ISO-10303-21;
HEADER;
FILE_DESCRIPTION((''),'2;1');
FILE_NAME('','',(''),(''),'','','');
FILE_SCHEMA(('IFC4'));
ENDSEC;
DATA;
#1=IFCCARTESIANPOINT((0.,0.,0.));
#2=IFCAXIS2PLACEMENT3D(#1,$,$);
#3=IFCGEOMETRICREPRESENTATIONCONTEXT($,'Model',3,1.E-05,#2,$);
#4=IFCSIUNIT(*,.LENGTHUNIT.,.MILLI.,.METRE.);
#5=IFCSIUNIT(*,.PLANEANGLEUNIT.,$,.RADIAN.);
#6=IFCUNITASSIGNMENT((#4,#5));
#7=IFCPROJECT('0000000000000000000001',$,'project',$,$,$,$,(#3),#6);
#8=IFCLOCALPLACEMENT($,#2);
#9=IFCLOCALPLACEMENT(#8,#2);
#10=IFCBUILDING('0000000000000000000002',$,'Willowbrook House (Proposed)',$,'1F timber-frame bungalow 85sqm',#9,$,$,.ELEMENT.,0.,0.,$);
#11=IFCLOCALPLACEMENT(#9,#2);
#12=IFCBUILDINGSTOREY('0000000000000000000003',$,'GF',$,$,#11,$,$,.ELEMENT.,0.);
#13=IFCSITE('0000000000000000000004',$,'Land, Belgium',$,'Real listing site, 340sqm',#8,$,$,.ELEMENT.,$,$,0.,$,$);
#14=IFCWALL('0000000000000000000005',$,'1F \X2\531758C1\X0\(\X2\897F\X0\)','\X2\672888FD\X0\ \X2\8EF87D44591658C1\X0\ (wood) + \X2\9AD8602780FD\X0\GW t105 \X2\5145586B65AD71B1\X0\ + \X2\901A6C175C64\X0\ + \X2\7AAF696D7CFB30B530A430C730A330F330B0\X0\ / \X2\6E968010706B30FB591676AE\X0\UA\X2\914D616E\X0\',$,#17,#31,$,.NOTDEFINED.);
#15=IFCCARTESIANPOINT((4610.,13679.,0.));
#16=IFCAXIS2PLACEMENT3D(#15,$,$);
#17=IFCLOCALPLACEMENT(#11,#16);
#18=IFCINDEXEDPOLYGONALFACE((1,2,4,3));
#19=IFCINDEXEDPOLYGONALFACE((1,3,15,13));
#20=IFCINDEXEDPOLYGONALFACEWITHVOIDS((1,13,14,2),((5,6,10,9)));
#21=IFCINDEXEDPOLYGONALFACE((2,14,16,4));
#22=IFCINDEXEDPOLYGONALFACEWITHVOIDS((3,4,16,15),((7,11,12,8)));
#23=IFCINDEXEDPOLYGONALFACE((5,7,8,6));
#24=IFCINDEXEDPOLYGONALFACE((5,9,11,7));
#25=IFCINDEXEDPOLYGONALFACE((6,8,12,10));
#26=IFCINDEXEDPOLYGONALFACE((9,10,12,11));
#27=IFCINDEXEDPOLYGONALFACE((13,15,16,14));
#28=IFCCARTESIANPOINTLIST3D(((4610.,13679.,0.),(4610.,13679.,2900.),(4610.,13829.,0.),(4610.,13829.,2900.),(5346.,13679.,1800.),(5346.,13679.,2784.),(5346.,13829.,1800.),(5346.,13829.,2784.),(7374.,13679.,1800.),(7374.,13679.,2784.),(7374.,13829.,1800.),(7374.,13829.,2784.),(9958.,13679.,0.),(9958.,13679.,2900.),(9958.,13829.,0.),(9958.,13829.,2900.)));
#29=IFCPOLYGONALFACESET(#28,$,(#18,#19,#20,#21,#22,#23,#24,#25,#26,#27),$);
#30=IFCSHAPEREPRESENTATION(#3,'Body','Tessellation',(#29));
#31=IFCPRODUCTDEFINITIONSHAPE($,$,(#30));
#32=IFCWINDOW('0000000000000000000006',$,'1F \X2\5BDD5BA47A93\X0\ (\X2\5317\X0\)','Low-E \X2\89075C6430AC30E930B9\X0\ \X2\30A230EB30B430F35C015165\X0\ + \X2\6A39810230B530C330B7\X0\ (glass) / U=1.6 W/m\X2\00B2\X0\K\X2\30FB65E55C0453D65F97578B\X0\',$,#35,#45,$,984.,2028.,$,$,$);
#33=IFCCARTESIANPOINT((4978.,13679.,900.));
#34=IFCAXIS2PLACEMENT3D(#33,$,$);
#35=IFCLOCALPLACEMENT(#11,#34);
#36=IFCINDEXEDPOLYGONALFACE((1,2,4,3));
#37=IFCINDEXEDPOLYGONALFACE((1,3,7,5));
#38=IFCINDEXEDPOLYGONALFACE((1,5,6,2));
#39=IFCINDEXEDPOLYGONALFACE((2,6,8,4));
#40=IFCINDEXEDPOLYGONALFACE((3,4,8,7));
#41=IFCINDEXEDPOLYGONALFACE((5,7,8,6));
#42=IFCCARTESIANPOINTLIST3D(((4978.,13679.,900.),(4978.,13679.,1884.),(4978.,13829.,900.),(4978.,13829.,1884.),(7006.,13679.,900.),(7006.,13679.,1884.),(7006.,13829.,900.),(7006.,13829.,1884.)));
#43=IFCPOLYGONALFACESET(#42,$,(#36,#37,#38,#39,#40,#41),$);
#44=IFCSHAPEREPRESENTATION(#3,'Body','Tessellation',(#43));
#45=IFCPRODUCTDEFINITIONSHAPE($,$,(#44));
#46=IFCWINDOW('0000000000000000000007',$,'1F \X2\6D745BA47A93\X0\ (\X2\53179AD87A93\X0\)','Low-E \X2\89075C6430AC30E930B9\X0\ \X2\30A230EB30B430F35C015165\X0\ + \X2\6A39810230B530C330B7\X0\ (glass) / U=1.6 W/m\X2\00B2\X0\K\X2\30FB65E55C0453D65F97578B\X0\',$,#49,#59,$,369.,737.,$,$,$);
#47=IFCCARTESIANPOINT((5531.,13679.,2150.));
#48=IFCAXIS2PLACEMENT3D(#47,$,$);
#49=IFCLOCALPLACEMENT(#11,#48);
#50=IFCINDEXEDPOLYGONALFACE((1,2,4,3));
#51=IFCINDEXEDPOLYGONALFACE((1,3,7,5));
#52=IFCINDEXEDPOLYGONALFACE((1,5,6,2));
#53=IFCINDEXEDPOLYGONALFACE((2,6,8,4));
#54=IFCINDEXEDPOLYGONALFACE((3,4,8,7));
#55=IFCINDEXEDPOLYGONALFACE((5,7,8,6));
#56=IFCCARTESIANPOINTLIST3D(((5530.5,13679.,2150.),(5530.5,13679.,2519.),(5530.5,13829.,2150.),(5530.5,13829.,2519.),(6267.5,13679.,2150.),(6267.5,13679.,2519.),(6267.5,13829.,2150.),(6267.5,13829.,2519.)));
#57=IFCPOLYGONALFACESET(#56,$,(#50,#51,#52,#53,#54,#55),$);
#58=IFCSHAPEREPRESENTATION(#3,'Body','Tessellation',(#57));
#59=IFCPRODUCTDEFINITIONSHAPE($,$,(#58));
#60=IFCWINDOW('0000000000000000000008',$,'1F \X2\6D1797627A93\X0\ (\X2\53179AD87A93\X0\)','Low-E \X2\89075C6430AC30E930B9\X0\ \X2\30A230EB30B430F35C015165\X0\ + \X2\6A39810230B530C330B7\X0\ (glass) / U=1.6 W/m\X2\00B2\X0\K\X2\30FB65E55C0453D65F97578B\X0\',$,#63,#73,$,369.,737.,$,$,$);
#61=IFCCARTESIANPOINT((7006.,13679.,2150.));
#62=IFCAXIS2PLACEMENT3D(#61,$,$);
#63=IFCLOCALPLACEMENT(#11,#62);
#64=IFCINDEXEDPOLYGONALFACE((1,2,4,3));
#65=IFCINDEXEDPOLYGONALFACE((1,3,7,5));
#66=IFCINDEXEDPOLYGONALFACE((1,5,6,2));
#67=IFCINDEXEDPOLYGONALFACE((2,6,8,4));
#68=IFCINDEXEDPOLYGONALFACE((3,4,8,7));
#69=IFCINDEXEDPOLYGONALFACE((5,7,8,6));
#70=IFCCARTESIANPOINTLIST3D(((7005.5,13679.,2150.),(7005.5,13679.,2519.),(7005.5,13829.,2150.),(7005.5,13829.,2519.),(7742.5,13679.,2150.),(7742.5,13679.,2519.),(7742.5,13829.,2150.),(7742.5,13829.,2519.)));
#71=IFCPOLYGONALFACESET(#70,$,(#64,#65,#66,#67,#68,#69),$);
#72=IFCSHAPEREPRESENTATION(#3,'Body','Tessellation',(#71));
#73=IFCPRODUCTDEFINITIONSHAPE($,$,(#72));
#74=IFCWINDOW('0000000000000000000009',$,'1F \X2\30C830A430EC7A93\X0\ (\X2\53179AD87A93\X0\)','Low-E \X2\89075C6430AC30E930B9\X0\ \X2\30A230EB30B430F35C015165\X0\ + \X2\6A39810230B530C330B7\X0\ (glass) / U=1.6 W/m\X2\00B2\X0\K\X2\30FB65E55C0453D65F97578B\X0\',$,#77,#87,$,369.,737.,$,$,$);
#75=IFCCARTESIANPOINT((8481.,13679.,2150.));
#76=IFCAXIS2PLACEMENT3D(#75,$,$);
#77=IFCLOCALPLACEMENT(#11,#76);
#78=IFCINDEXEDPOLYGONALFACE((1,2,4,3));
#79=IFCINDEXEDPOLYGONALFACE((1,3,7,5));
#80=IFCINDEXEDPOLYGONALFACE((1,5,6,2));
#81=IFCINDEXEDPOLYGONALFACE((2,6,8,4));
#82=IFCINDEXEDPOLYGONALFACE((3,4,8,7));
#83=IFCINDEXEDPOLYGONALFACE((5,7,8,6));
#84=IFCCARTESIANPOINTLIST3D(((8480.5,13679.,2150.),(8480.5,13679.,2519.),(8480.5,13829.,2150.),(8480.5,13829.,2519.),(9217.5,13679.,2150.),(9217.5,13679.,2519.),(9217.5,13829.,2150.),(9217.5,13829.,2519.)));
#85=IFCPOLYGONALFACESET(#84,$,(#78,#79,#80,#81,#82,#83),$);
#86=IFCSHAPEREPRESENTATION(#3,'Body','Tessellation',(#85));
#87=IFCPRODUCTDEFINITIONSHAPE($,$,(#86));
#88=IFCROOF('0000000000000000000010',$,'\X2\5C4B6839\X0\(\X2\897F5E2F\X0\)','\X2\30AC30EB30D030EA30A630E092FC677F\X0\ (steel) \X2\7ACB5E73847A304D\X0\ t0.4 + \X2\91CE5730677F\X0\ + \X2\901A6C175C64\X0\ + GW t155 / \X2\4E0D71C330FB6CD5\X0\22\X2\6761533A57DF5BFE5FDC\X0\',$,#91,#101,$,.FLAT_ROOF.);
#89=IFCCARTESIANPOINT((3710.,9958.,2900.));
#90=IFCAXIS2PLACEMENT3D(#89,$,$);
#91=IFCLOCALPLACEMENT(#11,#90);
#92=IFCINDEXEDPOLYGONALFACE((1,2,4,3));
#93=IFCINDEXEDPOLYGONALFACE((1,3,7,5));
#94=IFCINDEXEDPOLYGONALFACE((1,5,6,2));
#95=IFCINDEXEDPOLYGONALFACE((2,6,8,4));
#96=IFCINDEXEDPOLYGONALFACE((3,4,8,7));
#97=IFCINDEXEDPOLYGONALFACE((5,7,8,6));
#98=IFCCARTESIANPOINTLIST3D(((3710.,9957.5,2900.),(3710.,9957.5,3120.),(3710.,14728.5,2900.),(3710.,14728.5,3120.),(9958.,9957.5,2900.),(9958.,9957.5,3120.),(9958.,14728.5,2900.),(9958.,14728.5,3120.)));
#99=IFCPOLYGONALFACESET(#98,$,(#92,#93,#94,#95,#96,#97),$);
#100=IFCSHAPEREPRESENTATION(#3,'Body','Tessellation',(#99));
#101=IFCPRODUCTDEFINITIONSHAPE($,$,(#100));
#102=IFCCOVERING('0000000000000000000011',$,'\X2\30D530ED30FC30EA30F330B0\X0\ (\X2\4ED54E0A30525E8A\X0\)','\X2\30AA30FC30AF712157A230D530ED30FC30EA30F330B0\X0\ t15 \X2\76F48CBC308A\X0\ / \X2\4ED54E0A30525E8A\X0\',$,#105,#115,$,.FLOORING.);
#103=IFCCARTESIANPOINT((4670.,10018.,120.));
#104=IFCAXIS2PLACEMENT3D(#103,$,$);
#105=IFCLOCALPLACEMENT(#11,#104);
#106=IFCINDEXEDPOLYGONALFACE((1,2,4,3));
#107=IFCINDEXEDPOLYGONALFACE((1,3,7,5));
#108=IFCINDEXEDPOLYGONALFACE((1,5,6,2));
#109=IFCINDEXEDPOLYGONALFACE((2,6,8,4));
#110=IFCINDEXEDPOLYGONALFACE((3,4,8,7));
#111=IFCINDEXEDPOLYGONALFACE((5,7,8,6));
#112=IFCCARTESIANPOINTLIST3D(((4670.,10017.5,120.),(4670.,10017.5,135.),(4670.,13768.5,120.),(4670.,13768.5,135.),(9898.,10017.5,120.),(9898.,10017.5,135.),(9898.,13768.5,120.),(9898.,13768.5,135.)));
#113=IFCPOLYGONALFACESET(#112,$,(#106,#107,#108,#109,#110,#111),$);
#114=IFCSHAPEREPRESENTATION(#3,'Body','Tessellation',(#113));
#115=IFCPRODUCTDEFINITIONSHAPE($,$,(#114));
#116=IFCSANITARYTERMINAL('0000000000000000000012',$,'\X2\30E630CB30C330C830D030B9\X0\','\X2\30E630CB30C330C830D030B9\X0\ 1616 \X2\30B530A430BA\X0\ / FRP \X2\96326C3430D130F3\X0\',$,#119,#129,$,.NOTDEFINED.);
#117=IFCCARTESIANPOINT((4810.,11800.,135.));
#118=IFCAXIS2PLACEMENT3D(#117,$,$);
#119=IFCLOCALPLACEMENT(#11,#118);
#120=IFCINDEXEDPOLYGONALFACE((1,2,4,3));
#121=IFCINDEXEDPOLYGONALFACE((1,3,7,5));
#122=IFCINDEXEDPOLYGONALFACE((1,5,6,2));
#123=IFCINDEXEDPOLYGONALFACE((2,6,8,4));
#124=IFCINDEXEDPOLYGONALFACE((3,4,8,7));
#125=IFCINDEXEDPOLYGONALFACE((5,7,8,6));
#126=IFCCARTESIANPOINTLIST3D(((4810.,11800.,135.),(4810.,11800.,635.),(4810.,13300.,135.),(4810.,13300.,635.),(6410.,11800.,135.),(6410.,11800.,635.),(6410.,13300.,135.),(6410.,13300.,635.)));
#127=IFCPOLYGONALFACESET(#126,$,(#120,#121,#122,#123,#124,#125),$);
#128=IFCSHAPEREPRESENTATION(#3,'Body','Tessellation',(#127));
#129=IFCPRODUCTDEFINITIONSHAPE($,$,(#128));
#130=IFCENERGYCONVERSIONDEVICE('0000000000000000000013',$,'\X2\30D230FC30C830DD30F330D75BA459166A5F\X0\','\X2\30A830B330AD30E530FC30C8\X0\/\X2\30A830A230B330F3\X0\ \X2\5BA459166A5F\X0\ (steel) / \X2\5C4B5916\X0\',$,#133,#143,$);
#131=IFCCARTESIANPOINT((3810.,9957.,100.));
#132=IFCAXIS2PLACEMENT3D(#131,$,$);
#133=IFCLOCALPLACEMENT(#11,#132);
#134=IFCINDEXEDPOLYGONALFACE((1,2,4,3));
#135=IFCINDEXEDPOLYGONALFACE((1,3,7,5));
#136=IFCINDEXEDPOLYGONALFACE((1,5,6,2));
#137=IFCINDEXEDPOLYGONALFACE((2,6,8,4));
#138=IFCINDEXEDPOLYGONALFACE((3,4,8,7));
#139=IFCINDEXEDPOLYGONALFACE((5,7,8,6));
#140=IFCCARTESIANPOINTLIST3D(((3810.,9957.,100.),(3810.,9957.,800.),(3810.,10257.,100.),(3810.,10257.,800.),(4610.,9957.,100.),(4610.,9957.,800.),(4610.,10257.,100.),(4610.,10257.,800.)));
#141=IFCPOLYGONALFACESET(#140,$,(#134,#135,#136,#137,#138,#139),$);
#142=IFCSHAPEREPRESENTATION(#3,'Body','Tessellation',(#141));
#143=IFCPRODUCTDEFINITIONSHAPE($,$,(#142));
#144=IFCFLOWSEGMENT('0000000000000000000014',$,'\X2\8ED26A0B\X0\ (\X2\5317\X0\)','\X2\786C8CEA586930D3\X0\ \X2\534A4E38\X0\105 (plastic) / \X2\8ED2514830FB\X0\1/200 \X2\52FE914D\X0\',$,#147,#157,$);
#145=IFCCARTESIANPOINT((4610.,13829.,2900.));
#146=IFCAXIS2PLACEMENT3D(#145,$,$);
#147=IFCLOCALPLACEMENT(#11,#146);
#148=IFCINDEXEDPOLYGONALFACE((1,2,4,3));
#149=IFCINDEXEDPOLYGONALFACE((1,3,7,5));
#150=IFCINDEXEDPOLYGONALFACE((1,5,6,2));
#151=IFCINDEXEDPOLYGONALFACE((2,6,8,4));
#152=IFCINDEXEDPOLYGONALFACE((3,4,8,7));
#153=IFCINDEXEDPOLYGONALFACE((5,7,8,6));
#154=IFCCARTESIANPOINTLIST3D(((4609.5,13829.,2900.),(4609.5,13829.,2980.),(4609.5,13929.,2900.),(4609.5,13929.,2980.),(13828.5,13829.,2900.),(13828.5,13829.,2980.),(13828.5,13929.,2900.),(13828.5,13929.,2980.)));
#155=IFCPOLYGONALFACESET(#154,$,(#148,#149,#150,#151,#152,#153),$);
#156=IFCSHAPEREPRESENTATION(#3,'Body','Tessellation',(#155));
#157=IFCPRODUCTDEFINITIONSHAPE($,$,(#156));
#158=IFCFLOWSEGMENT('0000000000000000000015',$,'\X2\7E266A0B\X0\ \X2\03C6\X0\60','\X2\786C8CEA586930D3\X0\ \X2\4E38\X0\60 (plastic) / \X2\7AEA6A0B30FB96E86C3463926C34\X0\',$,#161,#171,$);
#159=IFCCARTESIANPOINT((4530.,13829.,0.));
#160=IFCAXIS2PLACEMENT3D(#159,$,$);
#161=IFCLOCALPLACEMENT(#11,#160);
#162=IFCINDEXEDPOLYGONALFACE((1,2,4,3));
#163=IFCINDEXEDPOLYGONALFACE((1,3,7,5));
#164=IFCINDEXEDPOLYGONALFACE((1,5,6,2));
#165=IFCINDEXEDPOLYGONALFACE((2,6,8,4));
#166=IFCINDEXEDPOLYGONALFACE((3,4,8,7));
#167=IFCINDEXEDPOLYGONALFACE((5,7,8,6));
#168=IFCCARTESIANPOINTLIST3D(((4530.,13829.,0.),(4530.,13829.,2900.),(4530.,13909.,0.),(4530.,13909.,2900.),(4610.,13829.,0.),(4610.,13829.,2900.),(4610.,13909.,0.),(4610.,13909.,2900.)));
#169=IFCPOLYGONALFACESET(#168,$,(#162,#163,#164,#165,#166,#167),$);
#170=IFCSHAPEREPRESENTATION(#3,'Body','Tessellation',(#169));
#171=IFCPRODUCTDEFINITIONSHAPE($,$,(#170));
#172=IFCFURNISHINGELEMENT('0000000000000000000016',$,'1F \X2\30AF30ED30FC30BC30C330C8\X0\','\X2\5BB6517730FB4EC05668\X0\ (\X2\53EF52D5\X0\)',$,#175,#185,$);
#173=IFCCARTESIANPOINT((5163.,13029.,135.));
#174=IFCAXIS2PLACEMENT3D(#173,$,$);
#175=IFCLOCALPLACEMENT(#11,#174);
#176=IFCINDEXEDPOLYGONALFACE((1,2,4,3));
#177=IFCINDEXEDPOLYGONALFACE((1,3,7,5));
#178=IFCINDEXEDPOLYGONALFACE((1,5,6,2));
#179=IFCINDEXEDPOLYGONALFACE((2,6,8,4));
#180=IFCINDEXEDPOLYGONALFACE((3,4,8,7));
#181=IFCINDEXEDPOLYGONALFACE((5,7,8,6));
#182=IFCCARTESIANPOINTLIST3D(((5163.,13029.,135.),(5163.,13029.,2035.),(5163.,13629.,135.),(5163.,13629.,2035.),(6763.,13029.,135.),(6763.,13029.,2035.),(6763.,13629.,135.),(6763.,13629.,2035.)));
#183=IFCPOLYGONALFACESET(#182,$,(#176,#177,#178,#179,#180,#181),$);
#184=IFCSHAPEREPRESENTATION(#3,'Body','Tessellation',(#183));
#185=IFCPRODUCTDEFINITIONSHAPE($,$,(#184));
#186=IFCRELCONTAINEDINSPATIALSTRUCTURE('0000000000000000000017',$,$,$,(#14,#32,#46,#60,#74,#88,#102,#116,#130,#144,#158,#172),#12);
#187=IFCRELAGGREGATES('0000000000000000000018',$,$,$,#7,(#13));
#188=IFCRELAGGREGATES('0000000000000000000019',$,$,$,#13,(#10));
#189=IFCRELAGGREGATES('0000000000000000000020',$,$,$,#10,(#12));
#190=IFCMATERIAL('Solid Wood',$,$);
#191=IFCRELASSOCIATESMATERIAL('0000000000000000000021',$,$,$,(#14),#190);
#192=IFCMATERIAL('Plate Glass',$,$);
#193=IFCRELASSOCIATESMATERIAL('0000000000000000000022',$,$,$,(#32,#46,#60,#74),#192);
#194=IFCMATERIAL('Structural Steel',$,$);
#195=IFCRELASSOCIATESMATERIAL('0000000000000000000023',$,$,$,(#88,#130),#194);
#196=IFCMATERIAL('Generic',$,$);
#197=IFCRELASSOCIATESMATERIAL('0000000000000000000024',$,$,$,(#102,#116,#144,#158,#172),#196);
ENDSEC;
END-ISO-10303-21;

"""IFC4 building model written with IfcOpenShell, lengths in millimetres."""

from ifc_helpers import new_model, si_unit, frame, frame_2d, origin, place, context, project, spatial, rectangle, extrude, material, element, fill, save


model = new_model("IFC4")

# Units and contexts
model_context = context("Model", 3, precision=1e-05, world=origin())
ifc_project = project(units=[si_unit("LENGTHUNIT", "METRE", prefix="MILLI"), si_unit("PLANEANGLEUNIT", "RADIAN")], contexts=[model_context])

# Site, building, storey
site_placement = place(None, origin())
site = spatial("IfcSite", under=ifc_project, at=site_placement, Name="Land, Belgium", ObjectType="Real listing site, 340sqm", CompositionType="ELEMENT", RefElevation=0.0)
building_placement = place(site_placement, origin())
building = spatial("IfcBuilding", under=site, at=building_placement, Name="Willowbrook House (Proposed)", ObjectType="1F timber-frame bungalow 85sqm", CompositionType="ELEMENT", ElevationOfRefHeight=0.0, ElevationOfTerrain=0.0)
storey_placement = place(building_placement, origin())
storey = spatial("IfcBuildingStorey", under=building, at=storey_placement, Name="GF", CompositionType="ELEMENT", Elevation=0.0)

# Shared definitions
ifc_material_1 = material(Name="Solid Wood")

# Wall, openings, windows
wall_1_placement = place(storey_placement, frame((4610.0, 13679.0, 0.0)))
wall_1 = element("IfcWall", 1, at=wall_1_placement, inside=storey, material=ifc_material_1, Name="1F 北壁(西)", Description="木製 軸組外壁 (wood) + 高性能GW t105 充填断熱 + 通気層 + 窯業系サイディング / 準耐火・外皮UA配慮", PredefinedType="NOTDEFINED", context=model_context, shape_type="SweptSolid", body=[
    extrude(rectangle(XDim=5348.0, YDim=150.0, at=frame_2d((2674.0, 75.0))), frame((4610.0, 13679.0, 0.0)), (0.0, 0.0, 1.0), 2900.0),
])
opening_1_placement = place(storey_placement, frame((4978.0, 13679.0, 900.0)))
opening_1 = element("IfcOpeningElement", 2, at=opening_1_placement, cuts=wall_1, PredefinedType="NOTDEFINED", context=model_context, shape_type="SweptSolid", body=[
    extrude(rectangle(XDim=2028.0, YDim=150.0, at=frame_2d((1014.0, 75.0))), frame((4978.0, 13679.0, 900.0)), (0.0, 0.0, 1.0), 984.0),
])
opening_2_placement = place(storey_placement, frame((5531.0, 13679.0, 2150.0)))
opening_2 = element("IfcOpeningElement", 3, at=opening_2_placement, cuts=wall_1, PredefinedType="NOTDEFINED", context=model_context, shape_type="SweptSolid", body=[
    extrude(rectangle(XDim=737.0, YDim=150.0, at=frame_2d((368.0, 75.0))), frame((5531.0, 13679.0, 2150.0)), (0.0, 0.0, 1.0), 369.0),
])
opening_3_placement = place(storey_placement, frame((7006.0, 13679.0, 2150.0)))
opening_3 = element("IfcOpeningElement", 4, at=opening_3_placement, cuts=wall_1, PredefinedType="NOTDEFINED", context=model_context, shape_type="SweptSolid", body=[
    extrude(rectangle(XDim=737.0, YDim=150.0, at=frame_2d((368.0, 75.0))), frame((7006.0, 13679.0, 2150.0)), (0.0, 0.0, 1.0), 369.0),
])
opening_4_placement = place(storey_placement, frame((8481.0, 13679.0, 2150.0)))
opening_4 = element("IfcOpeningElement", 5, at=opening_4_placement, cuts=wall_1, PredefinedType="NOTDEFINED", context=model_context, shape_type="SweptSolid", body=[
    extrude(rectangle(XDim=737.0, YDim=150.0, at=frame_2d((368.0, 75.0))), frame((8481.0, 13679.0, 2150.0)), (0.0, 0.0, 1.0), 369.0),
])
ifc_material_2 = material(Name="Plate Glass")
window_1_placement = place(storey_placement, frame((4978.0, 13679.0, 900.0)))
window_1 = element("IfcWindow", 6, at=window_1_placement, inside=storey, material=ifc_material_2, Name="1F 寝室窓 (北)", Description="Low-E 複層ガラス アルゴン封入 + 樹脂サッシ (glass) / U=1.6 W/m²K・日射取得型", OverallHeight=984.0, OverallWidth=2028.0, context=model_context, shape_type="SweptSolid", body=[
    extrude(rectangle(XDim=2028.0, YDim=150.0, at=frame_2d((1014.0, 75.0))), frame((4978.0, 13679.0, 900.0)), (0.0, 0.0, 1.0), 984.0),
])
fill(opening_1, window_1)
window_2_placement = place(storey_placement, frame((5531.0, 13679.0, 2150.0)))
window_2 = element("IfcWindow", 7, at=window_2_placement, inside=storey, material=ifc_material_2, Name="1F 浴室窓 (北高窓)", Description="Low-E 複層ガラス アルゴン封入 + 樹脂サッシ (glass) / U=1.6 W/m²K・日射取得型", OverallHeight=369.0, OverallWidth=737.0, context=model_context, shape_type="SweptSolid", body=[
    extrude(rectangle(XDim=737.0, YDim=150.0, at=frame_2d((368.0, 75.0))), frame((5531.0, 13679.0, 2150.0)), (0.0, 0.0, 1.0), 369.0),
])
fill(opening_2, window_2)
window_3_placement = place(storey_placement, frame((7006.0, 13679.0, 2150.0)))
window_3 = element("IfcWindow", 8, at=window_3_placement, inside=storey, material=ifc_material_2, Name="1F 洗面窓 (北高窓)", Description="Low-E 複層ガラス アルゴン封入 + 樹脂サッシ (glass) / U=1.6 W/m²K・日射取得型", OverallHeight=369.0, OverallWidth=737.0, context=model_context, shape_type="SweptSolid", body=[
    extrude(rectangle(XDim=737.0, YDim=150.0, at=frame_2d((368.0, 75.0))), frame((7006.0, 13679.0, 2150.0)), (0.0, 0.0, 1.0), 369.0),
])
fill(opening_3, window_3)
window_4_placement = place(storey_placement, frame((8481.0, 13679.0, 2150.0)))
window_4 = element("IfcWindow", 9, at=window_4_placement, inside=storey, material=ifc_material_2, Name="1F トイレ窓 (北高窓)", Description="Low-E 複層ガラス アルゴン封入 + 樹脂サッシ (glass) / U=1.6 W/m²K・日射取得型", OverallHeight=369.0, OverallWidth=737.0, context=model_context, shape_type="SweptSolid", body=[
    extrude(rectangle(XDim=737.0, YDim=150.0, at=frame_2d((368.0, 75.0))), frame((8481.0, 13679.0, 2150.0)), (0.0, 0.0, 1.0), 369.0),
])
fill(opening_4, window_4)

# Roof
ifc_material_3 = material(Name="Structural Steel")
roof_placement = place(storey_placement, frame((3710.0, 9958.0, 2900.0)))
element("IfcRoof", 10, at=roof_placement, inside=storey, material=ifc_material_3, Name="屋根(西帯)", Description="ガルバリウム鋼板 (steel) 立平葺き t0.4 + 野地板 + 通気層 + GW t155 / 不燃・法22条区域対応", PredefinedType="FLAT_ROOF", context=model_context, shape_type="SweptSolid", body=[
    extrude(rectangle(XDim=6248.0, YDim=4771.0, at=frame_2d((3124.0, 2385.0))), frame((3710.0, 9958.0, 2900.0)), (0.0, 0.0, 1.0), 220.0),
])

# Covering
ifc_material_4 = material(Name="Generic")
covering_placement = place(storey_placement, frame((4670.0, 10018.0, 120.0)))
element("IfcCovering", 11, at=covering_placement, inside=storey, material=ifc_material_4, Name="フローリング (仕上げ床)", Description="オーク無垢フローリング t15 直貼り / 仕上げ床", PredefinedType="FLOORING", context=model_context, shape_type="SweptSolid", body=[
    extrude(rectangle(XDim=5228.0, YDim=3751.0, at=frame_2d((2614.0, 1875.0))), frame((4670.0, 10018.0, 120.0)), (0.0, 0.0, 1.0), 15.0),
])

# Sanitary terminal
sanitary_terminal_placement = place(storey_placement, frame((4810.0, 11800.0, 135.0)))
element("IfcSanitaryTerminal", 12, at=sanitary_terminal_placement, inside=storey, material=ifc_material_4, Name="ユニットバス", Description="ユニットバス 1616 サイズ / FRP 防水パン", PredefinedType="NOTDEFINED", context=model_context, shape_type="SweptSolid", body=[
    extrude(rectangle(XDim=1600.0, YDim=1500.0, at=frame_2d((800.0, 750.0))), frame((4810.0, 11800.0, 135.0)), (0.0, 0.0, 1.0), 500.0),
])

# Energy conversion device
energy_conversion_device_placement = place(storey_placement, frame((3810.0, 9957.0, 100.0)))
element("IfcEnergyConversionDevice", 13, at=energy_conversion_device_placement, inside=storey, material=ifc_material_3, Name="ヒートポンプ室外機", Description="エコキュート/エアコン 室外機 (steel) / 屋外", context=model_context, shape_type="SweptSolid", body=[
    extrude(rectangle(XDim=800.0, YDim=300.0, at=frame_2d((400.0, 150.0))), frame((3810.0, 9957.0, 100.0)), (0.0, 0.0, 1.0), 700.0),
])

# Flow segments
flow_segment_1_placement = place(storey_placement, frame((4610.0, 13829.0, 2900.0)))
element("IfcFlowSegment", 14, at=flow_segment_1_placement, inside=storey, material=ifc_material_4, Name="軒樋 (北)", Description="硬質塩ビ 半丸105 (plastic) / 軒先・1/200 勾配", context=model_context, shape_type="SweptSolid", body=[
    extrude(rectangle(XDim=9219.0, YDim=100.0, at=frame_2d((4609.0, 50.0))), frame((4610.0, 13829.0, 2900.0)), (0.0, 0.0, 1.0), 80.0),
])
flow_segment_2_placement = place(storey_placement, frame((4530.0, 13829.0, 0.0)))
element("IfcFlowSegment", 15, at=flow_segment_2_placement, inside=storey, material=ifc_material_4, Name="縦樋 φ60", Description="硬質塩ビ 丸60 (plastic) / 竪樋・雨水排水", context=model_context, shape_type="SweptSolid", body=[
    extrude(rectangle(XDim=80.0, YDim=80.0, at=frame_2d((40.0, 40.0))), frame((4530.0, 13829.0, 0.0)), (0.0, 0.0, 1.0), 2900.0),
])

# Furnishing element
furnishing_1_placement = place(storey_placement, frame((5163.0, 13029.0, 135.0)))
element("IfcFurnishingElement", 16, at=furnishing_1_placement, inside=storey, material=ifc_material_4, Name="1F クローゼット", Description="家具・什器 (可動)", context=model_context, shape_type="SweptSolid", body=[
    extrude(rectangle(XDim=1600.0, YDim=600.0, at=frame_2d((800.0, 300.0))), frame((5163.0, 13029.0, 135.0)), (0.0, 0.0, 1.0), 1900.0),
])

save(model, "model.ifc")
